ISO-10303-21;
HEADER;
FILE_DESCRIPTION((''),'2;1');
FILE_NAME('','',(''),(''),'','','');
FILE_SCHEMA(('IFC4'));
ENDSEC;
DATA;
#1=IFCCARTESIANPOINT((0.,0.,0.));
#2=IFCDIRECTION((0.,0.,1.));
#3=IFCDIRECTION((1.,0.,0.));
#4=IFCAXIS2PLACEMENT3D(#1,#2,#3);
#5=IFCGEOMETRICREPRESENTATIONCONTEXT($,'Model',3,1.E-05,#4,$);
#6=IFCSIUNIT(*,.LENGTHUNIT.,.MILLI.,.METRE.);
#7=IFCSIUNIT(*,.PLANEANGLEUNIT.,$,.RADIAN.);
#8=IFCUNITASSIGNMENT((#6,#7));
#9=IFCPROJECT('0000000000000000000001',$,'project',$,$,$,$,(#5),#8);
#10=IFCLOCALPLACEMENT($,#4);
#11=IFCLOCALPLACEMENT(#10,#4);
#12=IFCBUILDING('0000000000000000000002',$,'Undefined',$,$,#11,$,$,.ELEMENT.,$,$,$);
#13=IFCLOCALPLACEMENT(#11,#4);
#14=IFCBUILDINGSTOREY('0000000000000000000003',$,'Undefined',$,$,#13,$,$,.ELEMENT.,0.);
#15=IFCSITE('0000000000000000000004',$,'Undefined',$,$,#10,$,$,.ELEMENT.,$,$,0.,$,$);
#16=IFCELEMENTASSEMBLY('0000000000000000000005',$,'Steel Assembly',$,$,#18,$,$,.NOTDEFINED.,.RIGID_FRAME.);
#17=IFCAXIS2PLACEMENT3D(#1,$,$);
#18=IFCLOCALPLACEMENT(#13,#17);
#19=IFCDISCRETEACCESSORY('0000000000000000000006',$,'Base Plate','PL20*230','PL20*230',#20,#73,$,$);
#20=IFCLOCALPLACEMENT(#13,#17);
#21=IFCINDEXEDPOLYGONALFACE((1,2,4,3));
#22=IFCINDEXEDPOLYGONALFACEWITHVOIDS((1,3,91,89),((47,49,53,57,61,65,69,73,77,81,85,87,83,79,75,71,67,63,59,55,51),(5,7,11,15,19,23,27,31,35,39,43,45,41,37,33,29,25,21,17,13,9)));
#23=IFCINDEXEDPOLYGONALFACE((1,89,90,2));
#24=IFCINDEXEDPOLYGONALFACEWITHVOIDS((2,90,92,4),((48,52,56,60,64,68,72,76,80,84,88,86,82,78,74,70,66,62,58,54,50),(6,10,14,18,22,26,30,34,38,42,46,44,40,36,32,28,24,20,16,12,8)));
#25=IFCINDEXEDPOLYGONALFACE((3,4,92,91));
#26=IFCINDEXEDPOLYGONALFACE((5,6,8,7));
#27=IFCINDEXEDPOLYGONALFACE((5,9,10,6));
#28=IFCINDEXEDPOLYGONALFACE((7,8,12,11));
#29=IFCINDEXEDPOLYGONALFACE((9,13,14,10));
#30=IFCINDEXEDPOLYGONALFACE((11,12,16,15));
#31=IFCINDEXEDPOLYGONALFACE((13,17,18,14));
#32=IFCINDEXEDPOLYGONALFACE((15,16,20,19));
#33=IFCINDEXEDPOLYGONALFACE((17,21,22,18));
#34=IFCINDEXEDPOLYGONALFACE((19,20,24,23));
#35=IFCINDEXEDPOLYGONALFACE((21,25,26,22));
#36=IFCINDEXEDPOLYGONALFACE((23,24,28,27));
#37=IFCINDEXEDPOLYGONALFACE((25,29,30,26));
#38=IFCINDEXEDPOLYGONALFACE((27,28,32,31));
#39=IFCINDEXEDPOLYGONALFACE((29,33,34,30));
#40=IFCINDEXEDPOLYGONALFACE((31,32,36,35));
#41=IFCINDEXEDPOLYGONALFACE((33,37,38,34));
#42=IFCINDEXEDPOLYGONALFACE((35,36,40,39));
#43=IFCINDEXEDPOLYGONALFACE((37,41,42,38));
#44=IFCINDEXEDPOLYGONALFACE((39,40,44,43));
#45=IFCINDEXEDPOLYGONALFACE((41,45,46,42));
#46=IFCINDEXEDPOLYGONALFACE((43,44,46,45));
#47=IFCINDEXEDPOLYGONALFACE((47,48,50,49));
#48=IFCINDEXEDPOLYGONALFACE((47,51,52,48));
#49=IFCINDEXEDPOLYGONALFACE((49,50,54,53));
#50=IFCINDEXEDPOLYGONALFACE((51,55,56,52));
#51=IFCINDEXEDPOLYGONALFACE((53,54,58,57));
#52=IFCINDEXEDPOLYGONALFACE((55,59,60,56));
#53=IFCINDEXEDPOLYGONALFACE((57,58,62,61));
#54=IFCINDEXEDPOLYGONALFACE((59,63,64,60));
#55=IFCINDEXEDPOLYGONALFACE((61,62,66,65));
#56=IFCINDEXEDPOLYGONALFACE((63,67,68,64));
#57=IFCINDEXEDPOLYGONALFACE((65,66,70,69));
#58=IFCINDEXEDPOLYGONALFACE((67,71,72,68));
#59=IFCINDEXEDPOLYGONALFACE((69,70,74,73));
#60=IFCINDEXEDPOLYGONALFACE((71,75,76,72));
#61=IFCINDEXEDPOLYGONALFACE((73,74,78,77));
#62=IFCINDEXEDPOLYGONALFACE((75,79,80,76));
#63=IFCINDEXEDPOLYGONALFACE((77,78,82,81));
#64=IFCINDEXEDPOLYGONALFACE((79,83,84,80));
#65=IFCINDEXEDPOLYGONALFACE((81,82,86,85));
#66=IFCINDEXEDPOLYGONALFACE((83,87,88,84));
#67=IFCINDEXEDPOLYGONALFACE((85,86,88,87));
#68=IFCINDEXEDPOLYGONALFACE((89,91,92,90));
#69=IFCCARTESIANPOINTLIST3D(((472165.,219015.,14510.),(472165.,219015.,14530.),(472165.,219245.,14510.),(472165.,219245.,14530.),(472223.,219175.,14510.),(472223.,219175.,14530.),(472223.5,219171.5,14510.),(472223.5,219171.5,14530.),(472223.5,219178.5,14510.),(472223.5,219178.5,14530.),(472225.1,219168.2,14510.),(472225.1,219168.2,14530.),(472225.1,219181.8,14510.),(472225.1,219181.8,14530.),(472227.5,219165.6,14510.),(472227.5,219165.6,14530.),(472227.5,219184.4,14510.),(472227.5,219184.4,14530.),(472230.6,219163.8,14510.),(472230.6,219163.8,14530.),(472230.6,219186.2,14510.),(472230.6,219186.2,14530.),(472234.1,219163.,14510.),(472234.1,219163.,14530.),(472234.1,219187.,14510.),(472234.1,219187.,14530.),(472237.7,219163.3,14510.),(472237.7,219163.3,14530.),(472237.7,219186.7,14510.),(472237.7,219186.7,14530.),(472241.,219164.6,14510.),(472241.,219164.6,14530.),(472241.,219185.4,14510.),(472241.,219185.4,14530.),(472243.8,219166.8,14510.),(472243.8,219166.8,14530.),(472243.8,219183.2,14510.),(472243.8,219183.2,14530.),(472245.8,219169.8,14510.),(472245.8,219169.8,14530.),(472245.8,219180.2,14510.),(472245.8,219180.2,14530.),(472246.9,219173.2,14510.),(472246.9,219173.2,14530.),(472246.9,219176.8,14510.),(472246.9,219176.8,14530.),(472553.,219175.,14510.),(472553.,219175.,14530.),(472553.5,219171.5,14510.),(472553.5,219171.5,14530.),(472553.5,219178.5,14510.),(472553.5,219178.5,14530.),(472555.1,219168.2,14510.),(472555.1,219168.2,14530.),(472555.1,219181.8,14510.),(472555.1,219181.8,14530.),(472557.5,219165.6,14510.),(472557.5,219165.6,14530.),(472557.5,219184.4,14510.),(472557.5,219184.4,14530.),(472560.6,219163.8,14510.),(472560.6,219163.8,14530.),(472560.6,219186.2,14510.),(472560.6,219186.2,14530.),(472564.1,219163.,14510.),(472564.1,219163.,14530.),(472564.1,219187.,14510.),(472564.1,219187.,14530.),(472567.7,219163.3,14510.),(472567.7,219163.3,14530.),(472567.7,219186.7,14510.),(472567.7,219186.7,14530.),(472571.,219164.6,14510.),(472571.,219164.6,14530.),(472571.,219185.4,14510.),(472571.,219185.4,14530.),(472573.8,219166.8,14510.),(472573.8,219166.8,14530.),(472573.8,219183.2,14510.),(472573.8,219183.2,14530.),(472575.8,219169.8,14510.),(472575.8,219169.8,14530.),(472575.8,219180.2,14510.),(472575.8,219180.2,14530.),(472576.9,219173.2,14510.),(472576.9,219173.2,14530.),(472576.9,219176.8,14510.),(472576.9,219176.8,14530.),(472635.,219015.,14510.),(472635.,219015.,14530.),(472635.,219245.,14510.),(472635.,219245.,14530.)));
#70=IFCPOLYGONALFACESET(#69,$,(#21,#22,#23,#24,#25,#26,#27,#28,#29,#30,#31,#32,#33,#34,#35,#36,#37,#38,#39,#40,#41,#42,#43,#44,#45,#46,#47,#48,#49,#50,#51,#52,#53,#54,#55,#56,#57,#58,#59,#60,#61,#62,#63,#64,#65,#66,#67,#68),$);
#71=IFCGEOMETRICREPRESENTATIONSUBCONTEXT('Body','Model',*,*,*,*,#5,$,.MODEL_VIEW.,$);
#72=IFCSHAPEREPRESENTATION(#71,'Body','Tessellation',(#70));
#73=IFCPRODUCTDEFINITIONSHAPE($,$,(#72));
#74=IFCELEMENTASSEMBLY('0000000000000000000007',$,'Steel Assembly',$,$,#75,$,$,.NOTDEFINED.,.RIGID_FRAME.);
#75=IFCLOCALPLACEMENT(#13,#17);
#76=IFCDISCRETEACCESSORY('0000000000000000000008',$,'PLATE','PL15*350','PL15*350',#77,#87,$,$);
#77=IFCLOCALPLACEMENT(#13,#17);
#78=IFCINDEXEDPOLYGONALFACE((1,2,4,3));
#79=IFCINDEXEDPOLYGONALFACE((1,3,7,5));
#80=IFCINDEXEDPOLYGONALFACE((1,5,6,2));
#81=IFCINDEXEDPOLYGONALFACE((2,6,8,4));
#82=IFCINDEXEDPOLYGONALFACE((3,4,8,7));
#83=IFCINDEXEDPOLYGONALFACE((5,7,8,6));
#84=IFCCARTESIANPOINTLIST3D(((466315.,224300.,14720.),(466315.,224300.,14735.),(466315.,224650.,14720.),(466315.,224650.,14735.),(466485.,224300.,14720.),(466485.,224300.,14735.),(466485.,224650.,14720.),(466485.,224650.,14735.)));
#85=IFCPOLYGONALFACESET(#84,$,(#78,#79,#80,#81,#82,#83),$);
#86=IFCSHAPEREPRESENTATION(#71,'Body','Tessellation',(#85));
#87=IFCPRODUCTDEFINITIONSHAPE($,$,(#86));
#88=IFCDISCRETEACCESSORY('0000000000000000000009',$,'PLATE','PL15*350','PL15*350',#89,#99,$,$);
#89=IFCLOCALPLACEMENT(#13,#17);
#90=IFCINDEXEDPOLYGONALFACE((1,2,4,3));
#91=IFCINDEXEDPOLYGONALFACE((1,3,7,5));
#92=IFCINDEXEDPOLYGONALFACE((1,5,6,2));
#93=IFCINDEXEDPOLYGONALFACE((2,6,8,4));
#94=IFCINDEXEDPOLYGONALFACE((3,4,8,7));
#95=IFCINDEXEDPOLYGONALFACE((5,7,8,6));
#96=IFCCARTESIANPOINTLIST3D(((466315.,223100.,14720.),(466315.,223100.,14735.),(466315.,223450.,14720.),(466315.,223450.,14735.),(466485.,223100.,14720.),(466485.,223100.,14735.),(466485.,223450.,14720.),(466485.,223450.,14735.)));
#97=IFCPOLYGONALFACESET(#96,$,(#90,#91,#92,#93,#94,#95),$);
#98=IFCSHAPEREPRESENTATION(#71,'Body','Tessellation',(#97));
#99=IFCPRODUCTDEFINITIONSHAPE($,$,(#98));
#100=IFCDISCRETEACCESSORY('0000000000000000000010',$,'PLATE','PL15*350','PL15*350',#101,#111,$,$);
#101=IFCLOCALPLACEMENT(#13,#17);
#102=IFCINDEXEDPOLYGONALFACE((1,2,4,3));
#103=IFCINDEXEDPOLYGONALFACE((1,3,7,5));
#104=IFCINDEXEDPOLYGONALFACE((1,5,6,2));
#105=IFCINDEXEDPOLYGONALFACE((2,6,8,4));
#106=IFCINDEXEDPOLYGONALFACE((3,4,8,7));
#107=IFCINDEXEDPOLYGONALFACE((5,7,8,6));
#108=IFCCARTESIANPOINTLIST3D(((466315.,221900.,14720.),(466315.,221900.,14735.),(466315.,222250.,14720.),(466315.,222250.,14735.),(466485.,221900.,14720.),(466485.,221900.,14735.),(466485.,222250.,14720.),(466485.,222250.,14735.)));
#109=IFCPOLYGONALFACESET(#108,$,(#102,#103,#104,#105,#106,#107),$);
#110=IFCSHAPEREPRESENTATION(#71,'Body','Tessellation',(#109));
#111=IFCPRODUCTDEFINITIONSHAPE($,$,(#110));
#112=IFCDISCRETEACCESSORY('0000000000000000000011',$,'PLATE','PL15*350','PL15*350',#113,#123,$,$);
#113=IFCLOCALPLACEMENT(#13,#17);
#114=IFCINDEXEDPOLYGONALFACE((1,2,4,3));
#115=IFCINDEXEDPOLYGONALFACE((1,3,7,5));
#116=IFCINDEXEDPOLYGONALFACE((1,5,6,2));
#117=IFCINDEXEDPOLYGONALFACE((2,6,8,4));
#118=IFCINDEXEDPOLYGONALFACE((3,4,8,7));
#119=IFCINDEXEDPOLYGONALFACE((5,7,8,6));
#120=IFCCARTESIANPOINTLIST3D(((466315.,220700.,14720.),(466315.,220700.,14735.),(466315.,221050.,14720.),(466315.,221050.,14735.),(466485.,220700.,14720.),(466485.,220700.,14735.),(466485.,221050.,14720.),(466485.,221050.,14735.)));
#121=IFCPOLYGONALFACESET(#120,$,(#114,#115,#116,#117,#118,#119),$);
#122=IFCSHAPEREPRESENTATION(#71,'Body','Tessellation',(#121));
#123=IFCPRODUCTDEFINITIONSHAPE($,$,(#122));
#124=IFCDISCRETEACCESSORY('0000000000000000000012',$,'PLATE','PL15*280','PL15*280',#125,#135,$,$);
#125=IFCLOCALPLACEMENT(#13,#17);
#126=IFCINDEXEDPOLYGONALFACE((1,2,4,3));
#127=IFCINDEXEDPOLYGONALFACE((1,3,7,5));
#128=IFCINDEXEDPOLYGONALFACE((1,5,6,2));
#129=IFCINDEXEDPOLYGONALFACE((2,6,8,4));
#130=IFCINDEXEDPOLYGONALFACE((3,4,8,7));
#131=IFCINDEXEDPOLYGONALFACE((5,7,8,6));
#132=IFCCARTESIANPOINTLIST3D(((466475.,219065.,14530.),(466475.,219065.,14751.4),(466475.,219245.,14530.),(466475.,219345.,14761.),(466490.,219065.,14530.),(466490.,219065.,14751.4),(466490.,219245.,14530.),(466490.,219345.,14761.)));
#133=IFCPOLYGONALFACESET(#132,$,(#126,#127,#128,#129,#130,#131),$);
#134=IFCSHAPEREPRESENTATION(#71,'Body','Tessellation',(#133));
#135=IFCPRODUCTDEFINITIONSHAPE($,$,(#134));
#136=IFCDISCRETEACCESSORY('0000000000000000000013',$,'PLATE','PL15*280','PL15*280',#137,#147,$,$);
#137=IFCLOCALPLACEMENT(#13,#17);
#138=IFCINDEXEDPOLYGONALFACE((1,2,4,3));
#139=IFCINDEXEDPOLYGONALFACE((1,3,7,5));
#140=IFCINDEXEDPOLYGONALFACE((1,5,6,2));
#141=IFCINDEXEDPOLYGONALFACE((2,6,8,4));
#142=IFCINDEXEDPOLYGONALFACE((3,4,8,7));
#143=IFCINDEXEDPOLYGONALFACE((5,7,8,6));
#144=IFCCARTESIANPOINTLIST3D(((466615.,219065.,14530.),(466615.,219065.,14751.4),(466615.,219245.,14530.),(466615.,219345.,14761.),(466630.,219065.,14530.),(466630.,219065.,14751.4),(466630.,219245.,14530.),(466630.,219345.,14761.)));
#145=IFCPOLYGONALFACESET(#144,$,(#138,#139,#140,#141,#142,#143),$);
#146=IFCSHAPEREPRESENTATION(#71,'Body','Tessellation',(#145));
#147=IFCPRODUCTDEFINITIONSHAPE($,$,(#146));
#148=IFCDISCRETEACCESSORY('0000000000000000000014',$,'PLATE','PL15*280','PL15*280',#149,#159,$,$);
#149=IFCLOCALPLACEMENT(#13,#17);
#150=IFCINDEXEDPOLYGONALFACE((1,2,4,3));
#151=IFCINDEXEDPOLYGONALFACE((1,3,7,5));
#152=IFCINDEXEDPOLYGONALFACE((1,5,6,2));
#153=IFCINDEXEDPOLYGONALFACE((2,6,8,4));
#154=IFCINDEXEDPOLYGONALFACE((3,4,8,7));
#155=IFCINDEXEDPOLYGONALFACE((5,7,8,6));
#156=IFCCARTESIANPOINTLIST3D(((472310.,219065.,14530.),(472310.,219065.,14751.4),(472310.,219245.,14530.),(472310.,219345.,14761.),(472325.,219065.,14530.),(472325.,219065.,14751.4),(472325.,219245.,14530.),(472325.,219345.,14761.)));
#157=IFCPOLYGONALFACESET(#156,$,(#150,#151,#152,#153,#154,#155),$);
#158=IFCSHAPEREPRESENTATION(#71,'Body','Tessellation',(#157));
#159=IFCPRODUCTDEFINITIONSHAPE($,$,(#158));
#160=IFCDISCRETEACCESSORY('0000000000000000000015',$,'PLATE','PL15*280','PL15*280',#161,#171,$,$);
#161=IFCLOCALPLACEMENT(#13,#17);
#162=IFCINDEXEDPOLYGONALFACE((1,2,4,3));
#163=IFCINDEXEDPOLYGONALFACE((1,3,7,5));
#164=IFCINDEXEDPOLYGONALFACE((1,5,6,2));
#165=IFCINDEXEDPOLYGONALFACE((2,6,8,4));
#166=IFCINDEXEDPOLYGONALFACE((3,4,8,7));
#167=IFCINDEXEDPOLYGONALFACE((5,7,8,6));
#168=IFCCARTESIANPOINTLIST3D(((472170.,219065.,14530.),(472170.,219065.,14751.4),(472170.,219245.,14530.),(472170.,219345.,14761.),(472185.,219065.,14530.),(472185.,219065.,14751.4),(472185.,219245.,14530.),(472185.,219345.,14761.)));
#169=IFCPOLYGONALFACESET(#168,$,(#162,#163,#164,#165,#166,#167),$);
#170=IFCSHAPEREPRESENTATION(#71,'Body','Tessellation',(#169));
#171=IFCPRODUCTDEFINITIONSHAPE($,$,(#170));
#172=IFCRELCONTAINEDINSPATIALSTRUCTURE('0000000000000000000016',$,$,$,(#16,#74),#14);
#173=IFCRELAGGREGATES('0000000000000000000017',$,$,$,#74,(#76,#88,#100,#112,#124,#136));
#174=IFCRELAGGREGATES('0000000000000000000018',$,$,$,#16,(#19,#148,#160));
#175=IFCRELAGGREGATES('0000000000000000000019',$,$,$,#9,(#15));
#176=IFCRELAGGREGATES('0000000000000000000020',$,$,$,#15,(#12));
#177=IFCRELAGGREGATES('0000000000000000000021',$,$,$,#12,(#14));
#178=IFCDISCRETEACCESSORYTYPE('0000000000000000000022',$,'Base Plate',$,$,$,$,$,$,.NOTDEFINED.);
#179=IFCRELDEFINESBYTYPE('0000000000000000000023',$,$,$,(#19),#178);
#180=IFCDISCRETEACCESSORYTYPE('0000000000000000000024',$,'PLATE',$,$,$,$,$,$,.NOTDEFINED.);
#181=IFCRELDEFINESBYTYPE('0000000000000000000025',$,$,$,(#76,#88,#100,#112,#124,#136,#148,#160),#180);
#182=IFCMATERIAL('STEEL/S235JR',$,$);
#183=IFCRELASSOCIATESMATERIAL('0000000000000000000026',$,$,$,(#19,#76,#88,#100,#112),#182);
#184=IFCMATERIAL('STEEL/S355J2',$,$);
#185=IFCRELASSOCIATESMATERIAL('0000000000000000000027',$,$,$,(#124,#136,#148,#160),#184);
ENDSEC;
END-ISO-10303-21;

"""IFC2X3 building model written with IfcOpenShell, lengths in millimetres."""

from ifc_helpers import new_model, si_unit, frame, origin_with_axes, origin_2d_with_axis, place, context, subcontext, project, spatial, polyline, circle, outline, extrude, boolean, material, type_object, element, aggregate, save


model = new_model("IFC2X3")

# Units and contexts
model_context = context("Model", 3, precision=1e-05, world=origin_with_axes())
body_context = subcontext(model_context, "Body", "Model", "MODEL_VIEW")
ifc_project = project(units=[si_unit("LENGTHUNIT", "METRE", prefix="MILLI"), si_unit("PLANEANGLEUNIT", "RADIAN")], contexts=[model_context])

# Site, building, storey
site_placement = place(None, origin_with_axes())
site = spatial("IfcSite", under=ifc_project, at=site_placement, Name="Undefined", CompositionType="ELEMENT", RefElevation=0.0)
building_placement = place(site_placement, origin_with_axes())
building = spatial("IfcBuilding", under=site, at=building_placement, Name="Undefined", CompositionType="ELEMENT")
storey_placement = place(building_placement, origin_with_axes())
storey = spatial("IfcBuildingStorey", under=building, at=storey_placement, Name="Undefined", CompositionType="ELEMENT", Elevation=0.0)

# Shared definitions
ifc_material_1 = material(Name="STEEL/S235JR")

# Shared definitions
ifc_material_2 = material(Name="STEEL/S355J2")

# Element assemblies, discrete accessories
assembly_1_placement = place(storey_placement, origin_with_axes())
assembly_1 = element("IfcElementAssembly", 1, at=assembly_1_placement, inside=storey, Name="Steel Assembly", AssemblyPlace="NOTDEFINED", PredefinedType="RIGID_FRAME")
discrete_accessory_type_1 = type_object("IfcDiscreteAccessoryType", Name="Base Plate")
discrete_accessory_1_placement = place(assembly_1_placement, frame((472165.0, 219245.0, 14520.0), z_axis=(0.0, 0.0, -1.0), x_axis=(1.0, 0.0, 0.0)))
discrete_accessory_1 = element("IfcDiscreteAccessory", 2, at=discrete_accessory_1_placement, type_object=discrete_accessory_type_1, material=ifc_material_1, Name="Base Plate", Description="PL20*230", ObjectType="PL20*230", context=body_context, shape_type="CSG", body=[
    boolean("DIFFERENCE", boolean("DIFFERENCE", extrude(outline(polyline([(0.0, 0.0), (470.0, 0.0), (470.0, 230.0), (0.0, 230.0), (0.0, 0.0)])), frame((0.0, 0.0, -10.0), z_axis=(0.0, 0.0, 1.0), x_axis=(1.0, 0.0, 0.0)), (0.0, 0.0, 1.0), 20.0), extrude(circle(Radius=12.0, at=origin_2d_with_axis()), frame((70.0, 70.0, -80.0), z_axis=(0.0, 0.0, 1.0), x_axis=(-1.0, 0.0, 0.0)), (0.0, 0.0, 1.0), 1160.0)), extrude(circle(Radius=12.0, at=origin_2d_with_axis()), frame((400.0, 70.0, -80.0), z_axis=(0.0, 0.0, 1.0), x_axis=(-1.0, 0.0, 0.0)), (0.0, 0.0, 1.0), 1160.0)),
])
assembly_2_placement = place(storey_placement, origin_with_axes())
assembly_2 = element("IfcElementAssembly", 3, at=assembly_2_placement, inside=storey, Name="Steel Assembly", AssemblyPlace="NOTDEFINED", PredefinedType="RIGID_FRAME")
discrete_accessory_type_2 = type_object("IfcDiscreteAccessoryType", Name="PLATE")
discrete_accessory_2_placement = place(assembly_2_placement, frame((466485.0, 224475.0, 14727.5), z_axis=(0.0, 0.0, 1.0), x_axis=(-1.0, 0.0, 0.0)))
discrete_accessory_2 = element("IfcDiscreteAccessory", 4, at=discrete_accessory_2_placement, type_object=discrete_accessory_type_2, material=ifc_material_1, Name="PLATE", Description="PL15*350", ObjectType="PL15*350", context=body_context, shape_type="SweptSolid", body=[
    extrude(outline(polyline([(170.0, -175.0), (0.0, -175.0), (0.0, 175.0), (170.0, 175.0), (170.0, -175.0)])), frame((0.0, 0.0, -7.5), z_axis=(0.0, 0.0, 1.0), x_axis=(1.0, 0.0, 0.0)), (0.0, 0.0, 1.0), 15.0),
])
discrete_accessory_3_placement = place(assembly_2_placement, frame((466485.0, 223275.0, 14727.5), z_axis=(0.0, 0.0, 1.0), x_axis=(-1.0, 0.0, 0.0)))
discrete_accessory_3 = element("IfcDiscreteAccessory", 5, at=discrete_accessory_3_placement, type_object=discrete_accessory_type_2, material=ifc_material_1, Name="PLATE", Description="PL15*350", ObjectType="PL15*350", context=body_context, shape_type="SweptSolid", body=[
    extrude(outline(polyline([(170.0, -175.0), (0.0, -175.0), (0.0, 175.0), (170.0, 175.0), (170.0, -175.0)])), frame((0.0, 0.0, -7.5), z_axis=(0.0, 0.0, 1.0), x_axis=(1.0, 0.0, 0.0)), (0.0, 0.0, 1.0), 15.0),
])
discrete_accessory_4_placement = place(assembly_2_placement, frame((466485.0, 222075.0, 14727.5), z_axis=(0.0, 0.0, 1.0), x_axis=(-1.0, 0.0, 0.0)))
discrete_accessory_4 = element("IfcDiscreteAccessory", 6, at=discrete_accessory_4_placement, type_object=discrete_accessory_type_2, material=ifc_material_1, Name="PLATE", Description="PL15*350", ObjectType="PL15*350", context=body_context, shape_type="SweptSolid", body=[
    extrude(outline(polyline([(170.0, -175.0), (0.0, -175.0), (0.0, 175.0), (170.0, 175.0), (170.0, -175.0)])), frame((0.0, 0.0, -7.5), z_axis=(0.0, 0.0, 1.0), x_axis=(1.0, 0.0, 0.0)), (0.0, 0.0, 1.0), 15.0),
])
discrete_accessory_5_placement = place(assembly_2_placement, frame((466485.0, 220875.0, 14727.5), z_axis=(0.0, 0.0, 1.0), x_axis=(-1.0, 0.0, 0.0)))
discrete_accessory_5 = element("IfcDiscreteAccessory", 7, at=discrete_accessory_5_placement, type_object=discrete_accessory_type_2, material=ifc_material_1, Name="PLATE", Description="PL15*350", ObjectType="PL15*350", context=body_context, shape_type="SweptSolid", body=[
    extrude(outline(polyline([(170.0, -175.0), (0.0, -175.0), (0.0, 175.0), (170.0, 175.0), (170.0, -175.0)])), frame((0.0, 0.0, -7.5), z_axis=(0.0, 0.0, 1.0), x_axis=(1.0, 0.0, 0.0)), (0.0, 0.0, 1.0), 15.0),
])
discrete_accessory_6_placement = place(assembly_2_placement, frame((466482.5, 219065.0, 14530.0), z_axis=(1.0, 0.0, 0.0), x_axis=(0.0, 1.0, 0.0)))
discrete_accessory_6 = element("IfcDiscreteAccessory", 8, at=discrete_accessory_6_placement, type_object=discrete_accessory_type_2, material=ifc_material_2, Name="PLATE", Description="PL15*280", ObjectType="PL15*280", context=body_context, shape_type="SweptSolid", body=[
    extrude(outline(polyline([(0.0, 0.0), (180.0, 0.0), (280.0, 231.0), (0.0, 221.4), (0.0, 0.0)])), frame((0.0, 0.0, -7.5), z_axis=(0.0, 0.0, 1.0), x_axis=(1.0, 0.0, 0.0)), (0.0, 0.0, 1.0), 15.0),
])
discrete_accessory_7_placement = place(assembly_2_placement, frame((466622.5, 219065.0, 14530.0), z_axis=(1.0, 0.0, 0.0), x_axis=(0.0, 1.0, 0.0)))
discrete_accessory_7 = element("IfcDiscreteAccessory", 9, at=discrete_accessory_7_placement, type_object=discrete_accessory_type_2, material=ifc_material_2, Name="PLATE", Description="PL15*280", ObjectType="PL15*280", context=body_context, shape_type="SweptSolid", body=[
    extrude(outline(polyline([(0.0, 0.0), (180.0, 0.0), (280.0, 231.0), (0.0, 221.4), (0.0, 0.0)])), frame((0.0, 0.0, -7.5), z_axis=(0.0, 0.0, 1.0), x_axis=(1.0, 0.0, 0.0)), (0.0, 0.0, 1.0), 15.0),
])
aggregate(assembly_2, [discrete_accessory_2, discrete_accessory_3, discrete_accessory_4, discrete_accessory_5, discrete_accessory_6, discrete_accessory_7])

# Discrete accessories
discrete_accessory_8_placement = place(assembly_1_placement, frame((472317.5, 219065.0, 14530.0), z_axis=(1.0, 0.0, 0.0), x_axis=(0.0, 1.0, 0.0)))
discrete_accessory_8 = element("IfcDiscreteAccessory", 10, at=discrete_accessory_8_placement, type_object=discrete_accessory_type_2, material=ifc_material_2, Name="PLATE", Description="PL15*280", ObjectType="PL15*280", context=body_context, shape_type="SweptSolid", body=[
    extrude(outline(polyline([(0.0, 0.0), (180.0, 0.0), (280.0, 231.0), (0.0, 221.4), (0.0, 0.0)])), frame((0.0, 0.0, -7.5), z_axis=(0.0, 0.0, 1.0), x_axis=(1.0, 0.0, 0.0)), (0.0, 0.0, 1.0), 15.0),
])
discrete_accessory_9_placement = place(assembly_1_placement, frame((472177.5, 219065.0, 14530.0), z_axis=(1.0, 0.0, 0.0), x_axis=(0.0, 1.0, 0.0)))
discrete_accessory_9 = element("IfcDiscreteAccessory", 11, at=discrete_accessory_9_placement, type_object=discrete_accessory_type_2, material=ifc_material_2, Name="PLATE", Description="PL15*280", ObjectType="PL15*280", context=body_context, shape_type="SweptSolid", body=[
    extrude(outline(polyline([(0.0, 0.0), (180.0, 0.0), (280.0, 231.0), (0.0, 221.4), (0.0, 0.0)])), frame((0.0, 0.0, -7.5), z_axis=(0.0, 0.0, 1.0), x_axis=(1.0, 0.0, 0.0)), (0.0, 0.0, 1.0), 15.0),
])
aggregate(assembly_1, [discrete_accessory_1, discrete_accessory_8, discrete_accessory_9])

save(model, "model.ifc")
